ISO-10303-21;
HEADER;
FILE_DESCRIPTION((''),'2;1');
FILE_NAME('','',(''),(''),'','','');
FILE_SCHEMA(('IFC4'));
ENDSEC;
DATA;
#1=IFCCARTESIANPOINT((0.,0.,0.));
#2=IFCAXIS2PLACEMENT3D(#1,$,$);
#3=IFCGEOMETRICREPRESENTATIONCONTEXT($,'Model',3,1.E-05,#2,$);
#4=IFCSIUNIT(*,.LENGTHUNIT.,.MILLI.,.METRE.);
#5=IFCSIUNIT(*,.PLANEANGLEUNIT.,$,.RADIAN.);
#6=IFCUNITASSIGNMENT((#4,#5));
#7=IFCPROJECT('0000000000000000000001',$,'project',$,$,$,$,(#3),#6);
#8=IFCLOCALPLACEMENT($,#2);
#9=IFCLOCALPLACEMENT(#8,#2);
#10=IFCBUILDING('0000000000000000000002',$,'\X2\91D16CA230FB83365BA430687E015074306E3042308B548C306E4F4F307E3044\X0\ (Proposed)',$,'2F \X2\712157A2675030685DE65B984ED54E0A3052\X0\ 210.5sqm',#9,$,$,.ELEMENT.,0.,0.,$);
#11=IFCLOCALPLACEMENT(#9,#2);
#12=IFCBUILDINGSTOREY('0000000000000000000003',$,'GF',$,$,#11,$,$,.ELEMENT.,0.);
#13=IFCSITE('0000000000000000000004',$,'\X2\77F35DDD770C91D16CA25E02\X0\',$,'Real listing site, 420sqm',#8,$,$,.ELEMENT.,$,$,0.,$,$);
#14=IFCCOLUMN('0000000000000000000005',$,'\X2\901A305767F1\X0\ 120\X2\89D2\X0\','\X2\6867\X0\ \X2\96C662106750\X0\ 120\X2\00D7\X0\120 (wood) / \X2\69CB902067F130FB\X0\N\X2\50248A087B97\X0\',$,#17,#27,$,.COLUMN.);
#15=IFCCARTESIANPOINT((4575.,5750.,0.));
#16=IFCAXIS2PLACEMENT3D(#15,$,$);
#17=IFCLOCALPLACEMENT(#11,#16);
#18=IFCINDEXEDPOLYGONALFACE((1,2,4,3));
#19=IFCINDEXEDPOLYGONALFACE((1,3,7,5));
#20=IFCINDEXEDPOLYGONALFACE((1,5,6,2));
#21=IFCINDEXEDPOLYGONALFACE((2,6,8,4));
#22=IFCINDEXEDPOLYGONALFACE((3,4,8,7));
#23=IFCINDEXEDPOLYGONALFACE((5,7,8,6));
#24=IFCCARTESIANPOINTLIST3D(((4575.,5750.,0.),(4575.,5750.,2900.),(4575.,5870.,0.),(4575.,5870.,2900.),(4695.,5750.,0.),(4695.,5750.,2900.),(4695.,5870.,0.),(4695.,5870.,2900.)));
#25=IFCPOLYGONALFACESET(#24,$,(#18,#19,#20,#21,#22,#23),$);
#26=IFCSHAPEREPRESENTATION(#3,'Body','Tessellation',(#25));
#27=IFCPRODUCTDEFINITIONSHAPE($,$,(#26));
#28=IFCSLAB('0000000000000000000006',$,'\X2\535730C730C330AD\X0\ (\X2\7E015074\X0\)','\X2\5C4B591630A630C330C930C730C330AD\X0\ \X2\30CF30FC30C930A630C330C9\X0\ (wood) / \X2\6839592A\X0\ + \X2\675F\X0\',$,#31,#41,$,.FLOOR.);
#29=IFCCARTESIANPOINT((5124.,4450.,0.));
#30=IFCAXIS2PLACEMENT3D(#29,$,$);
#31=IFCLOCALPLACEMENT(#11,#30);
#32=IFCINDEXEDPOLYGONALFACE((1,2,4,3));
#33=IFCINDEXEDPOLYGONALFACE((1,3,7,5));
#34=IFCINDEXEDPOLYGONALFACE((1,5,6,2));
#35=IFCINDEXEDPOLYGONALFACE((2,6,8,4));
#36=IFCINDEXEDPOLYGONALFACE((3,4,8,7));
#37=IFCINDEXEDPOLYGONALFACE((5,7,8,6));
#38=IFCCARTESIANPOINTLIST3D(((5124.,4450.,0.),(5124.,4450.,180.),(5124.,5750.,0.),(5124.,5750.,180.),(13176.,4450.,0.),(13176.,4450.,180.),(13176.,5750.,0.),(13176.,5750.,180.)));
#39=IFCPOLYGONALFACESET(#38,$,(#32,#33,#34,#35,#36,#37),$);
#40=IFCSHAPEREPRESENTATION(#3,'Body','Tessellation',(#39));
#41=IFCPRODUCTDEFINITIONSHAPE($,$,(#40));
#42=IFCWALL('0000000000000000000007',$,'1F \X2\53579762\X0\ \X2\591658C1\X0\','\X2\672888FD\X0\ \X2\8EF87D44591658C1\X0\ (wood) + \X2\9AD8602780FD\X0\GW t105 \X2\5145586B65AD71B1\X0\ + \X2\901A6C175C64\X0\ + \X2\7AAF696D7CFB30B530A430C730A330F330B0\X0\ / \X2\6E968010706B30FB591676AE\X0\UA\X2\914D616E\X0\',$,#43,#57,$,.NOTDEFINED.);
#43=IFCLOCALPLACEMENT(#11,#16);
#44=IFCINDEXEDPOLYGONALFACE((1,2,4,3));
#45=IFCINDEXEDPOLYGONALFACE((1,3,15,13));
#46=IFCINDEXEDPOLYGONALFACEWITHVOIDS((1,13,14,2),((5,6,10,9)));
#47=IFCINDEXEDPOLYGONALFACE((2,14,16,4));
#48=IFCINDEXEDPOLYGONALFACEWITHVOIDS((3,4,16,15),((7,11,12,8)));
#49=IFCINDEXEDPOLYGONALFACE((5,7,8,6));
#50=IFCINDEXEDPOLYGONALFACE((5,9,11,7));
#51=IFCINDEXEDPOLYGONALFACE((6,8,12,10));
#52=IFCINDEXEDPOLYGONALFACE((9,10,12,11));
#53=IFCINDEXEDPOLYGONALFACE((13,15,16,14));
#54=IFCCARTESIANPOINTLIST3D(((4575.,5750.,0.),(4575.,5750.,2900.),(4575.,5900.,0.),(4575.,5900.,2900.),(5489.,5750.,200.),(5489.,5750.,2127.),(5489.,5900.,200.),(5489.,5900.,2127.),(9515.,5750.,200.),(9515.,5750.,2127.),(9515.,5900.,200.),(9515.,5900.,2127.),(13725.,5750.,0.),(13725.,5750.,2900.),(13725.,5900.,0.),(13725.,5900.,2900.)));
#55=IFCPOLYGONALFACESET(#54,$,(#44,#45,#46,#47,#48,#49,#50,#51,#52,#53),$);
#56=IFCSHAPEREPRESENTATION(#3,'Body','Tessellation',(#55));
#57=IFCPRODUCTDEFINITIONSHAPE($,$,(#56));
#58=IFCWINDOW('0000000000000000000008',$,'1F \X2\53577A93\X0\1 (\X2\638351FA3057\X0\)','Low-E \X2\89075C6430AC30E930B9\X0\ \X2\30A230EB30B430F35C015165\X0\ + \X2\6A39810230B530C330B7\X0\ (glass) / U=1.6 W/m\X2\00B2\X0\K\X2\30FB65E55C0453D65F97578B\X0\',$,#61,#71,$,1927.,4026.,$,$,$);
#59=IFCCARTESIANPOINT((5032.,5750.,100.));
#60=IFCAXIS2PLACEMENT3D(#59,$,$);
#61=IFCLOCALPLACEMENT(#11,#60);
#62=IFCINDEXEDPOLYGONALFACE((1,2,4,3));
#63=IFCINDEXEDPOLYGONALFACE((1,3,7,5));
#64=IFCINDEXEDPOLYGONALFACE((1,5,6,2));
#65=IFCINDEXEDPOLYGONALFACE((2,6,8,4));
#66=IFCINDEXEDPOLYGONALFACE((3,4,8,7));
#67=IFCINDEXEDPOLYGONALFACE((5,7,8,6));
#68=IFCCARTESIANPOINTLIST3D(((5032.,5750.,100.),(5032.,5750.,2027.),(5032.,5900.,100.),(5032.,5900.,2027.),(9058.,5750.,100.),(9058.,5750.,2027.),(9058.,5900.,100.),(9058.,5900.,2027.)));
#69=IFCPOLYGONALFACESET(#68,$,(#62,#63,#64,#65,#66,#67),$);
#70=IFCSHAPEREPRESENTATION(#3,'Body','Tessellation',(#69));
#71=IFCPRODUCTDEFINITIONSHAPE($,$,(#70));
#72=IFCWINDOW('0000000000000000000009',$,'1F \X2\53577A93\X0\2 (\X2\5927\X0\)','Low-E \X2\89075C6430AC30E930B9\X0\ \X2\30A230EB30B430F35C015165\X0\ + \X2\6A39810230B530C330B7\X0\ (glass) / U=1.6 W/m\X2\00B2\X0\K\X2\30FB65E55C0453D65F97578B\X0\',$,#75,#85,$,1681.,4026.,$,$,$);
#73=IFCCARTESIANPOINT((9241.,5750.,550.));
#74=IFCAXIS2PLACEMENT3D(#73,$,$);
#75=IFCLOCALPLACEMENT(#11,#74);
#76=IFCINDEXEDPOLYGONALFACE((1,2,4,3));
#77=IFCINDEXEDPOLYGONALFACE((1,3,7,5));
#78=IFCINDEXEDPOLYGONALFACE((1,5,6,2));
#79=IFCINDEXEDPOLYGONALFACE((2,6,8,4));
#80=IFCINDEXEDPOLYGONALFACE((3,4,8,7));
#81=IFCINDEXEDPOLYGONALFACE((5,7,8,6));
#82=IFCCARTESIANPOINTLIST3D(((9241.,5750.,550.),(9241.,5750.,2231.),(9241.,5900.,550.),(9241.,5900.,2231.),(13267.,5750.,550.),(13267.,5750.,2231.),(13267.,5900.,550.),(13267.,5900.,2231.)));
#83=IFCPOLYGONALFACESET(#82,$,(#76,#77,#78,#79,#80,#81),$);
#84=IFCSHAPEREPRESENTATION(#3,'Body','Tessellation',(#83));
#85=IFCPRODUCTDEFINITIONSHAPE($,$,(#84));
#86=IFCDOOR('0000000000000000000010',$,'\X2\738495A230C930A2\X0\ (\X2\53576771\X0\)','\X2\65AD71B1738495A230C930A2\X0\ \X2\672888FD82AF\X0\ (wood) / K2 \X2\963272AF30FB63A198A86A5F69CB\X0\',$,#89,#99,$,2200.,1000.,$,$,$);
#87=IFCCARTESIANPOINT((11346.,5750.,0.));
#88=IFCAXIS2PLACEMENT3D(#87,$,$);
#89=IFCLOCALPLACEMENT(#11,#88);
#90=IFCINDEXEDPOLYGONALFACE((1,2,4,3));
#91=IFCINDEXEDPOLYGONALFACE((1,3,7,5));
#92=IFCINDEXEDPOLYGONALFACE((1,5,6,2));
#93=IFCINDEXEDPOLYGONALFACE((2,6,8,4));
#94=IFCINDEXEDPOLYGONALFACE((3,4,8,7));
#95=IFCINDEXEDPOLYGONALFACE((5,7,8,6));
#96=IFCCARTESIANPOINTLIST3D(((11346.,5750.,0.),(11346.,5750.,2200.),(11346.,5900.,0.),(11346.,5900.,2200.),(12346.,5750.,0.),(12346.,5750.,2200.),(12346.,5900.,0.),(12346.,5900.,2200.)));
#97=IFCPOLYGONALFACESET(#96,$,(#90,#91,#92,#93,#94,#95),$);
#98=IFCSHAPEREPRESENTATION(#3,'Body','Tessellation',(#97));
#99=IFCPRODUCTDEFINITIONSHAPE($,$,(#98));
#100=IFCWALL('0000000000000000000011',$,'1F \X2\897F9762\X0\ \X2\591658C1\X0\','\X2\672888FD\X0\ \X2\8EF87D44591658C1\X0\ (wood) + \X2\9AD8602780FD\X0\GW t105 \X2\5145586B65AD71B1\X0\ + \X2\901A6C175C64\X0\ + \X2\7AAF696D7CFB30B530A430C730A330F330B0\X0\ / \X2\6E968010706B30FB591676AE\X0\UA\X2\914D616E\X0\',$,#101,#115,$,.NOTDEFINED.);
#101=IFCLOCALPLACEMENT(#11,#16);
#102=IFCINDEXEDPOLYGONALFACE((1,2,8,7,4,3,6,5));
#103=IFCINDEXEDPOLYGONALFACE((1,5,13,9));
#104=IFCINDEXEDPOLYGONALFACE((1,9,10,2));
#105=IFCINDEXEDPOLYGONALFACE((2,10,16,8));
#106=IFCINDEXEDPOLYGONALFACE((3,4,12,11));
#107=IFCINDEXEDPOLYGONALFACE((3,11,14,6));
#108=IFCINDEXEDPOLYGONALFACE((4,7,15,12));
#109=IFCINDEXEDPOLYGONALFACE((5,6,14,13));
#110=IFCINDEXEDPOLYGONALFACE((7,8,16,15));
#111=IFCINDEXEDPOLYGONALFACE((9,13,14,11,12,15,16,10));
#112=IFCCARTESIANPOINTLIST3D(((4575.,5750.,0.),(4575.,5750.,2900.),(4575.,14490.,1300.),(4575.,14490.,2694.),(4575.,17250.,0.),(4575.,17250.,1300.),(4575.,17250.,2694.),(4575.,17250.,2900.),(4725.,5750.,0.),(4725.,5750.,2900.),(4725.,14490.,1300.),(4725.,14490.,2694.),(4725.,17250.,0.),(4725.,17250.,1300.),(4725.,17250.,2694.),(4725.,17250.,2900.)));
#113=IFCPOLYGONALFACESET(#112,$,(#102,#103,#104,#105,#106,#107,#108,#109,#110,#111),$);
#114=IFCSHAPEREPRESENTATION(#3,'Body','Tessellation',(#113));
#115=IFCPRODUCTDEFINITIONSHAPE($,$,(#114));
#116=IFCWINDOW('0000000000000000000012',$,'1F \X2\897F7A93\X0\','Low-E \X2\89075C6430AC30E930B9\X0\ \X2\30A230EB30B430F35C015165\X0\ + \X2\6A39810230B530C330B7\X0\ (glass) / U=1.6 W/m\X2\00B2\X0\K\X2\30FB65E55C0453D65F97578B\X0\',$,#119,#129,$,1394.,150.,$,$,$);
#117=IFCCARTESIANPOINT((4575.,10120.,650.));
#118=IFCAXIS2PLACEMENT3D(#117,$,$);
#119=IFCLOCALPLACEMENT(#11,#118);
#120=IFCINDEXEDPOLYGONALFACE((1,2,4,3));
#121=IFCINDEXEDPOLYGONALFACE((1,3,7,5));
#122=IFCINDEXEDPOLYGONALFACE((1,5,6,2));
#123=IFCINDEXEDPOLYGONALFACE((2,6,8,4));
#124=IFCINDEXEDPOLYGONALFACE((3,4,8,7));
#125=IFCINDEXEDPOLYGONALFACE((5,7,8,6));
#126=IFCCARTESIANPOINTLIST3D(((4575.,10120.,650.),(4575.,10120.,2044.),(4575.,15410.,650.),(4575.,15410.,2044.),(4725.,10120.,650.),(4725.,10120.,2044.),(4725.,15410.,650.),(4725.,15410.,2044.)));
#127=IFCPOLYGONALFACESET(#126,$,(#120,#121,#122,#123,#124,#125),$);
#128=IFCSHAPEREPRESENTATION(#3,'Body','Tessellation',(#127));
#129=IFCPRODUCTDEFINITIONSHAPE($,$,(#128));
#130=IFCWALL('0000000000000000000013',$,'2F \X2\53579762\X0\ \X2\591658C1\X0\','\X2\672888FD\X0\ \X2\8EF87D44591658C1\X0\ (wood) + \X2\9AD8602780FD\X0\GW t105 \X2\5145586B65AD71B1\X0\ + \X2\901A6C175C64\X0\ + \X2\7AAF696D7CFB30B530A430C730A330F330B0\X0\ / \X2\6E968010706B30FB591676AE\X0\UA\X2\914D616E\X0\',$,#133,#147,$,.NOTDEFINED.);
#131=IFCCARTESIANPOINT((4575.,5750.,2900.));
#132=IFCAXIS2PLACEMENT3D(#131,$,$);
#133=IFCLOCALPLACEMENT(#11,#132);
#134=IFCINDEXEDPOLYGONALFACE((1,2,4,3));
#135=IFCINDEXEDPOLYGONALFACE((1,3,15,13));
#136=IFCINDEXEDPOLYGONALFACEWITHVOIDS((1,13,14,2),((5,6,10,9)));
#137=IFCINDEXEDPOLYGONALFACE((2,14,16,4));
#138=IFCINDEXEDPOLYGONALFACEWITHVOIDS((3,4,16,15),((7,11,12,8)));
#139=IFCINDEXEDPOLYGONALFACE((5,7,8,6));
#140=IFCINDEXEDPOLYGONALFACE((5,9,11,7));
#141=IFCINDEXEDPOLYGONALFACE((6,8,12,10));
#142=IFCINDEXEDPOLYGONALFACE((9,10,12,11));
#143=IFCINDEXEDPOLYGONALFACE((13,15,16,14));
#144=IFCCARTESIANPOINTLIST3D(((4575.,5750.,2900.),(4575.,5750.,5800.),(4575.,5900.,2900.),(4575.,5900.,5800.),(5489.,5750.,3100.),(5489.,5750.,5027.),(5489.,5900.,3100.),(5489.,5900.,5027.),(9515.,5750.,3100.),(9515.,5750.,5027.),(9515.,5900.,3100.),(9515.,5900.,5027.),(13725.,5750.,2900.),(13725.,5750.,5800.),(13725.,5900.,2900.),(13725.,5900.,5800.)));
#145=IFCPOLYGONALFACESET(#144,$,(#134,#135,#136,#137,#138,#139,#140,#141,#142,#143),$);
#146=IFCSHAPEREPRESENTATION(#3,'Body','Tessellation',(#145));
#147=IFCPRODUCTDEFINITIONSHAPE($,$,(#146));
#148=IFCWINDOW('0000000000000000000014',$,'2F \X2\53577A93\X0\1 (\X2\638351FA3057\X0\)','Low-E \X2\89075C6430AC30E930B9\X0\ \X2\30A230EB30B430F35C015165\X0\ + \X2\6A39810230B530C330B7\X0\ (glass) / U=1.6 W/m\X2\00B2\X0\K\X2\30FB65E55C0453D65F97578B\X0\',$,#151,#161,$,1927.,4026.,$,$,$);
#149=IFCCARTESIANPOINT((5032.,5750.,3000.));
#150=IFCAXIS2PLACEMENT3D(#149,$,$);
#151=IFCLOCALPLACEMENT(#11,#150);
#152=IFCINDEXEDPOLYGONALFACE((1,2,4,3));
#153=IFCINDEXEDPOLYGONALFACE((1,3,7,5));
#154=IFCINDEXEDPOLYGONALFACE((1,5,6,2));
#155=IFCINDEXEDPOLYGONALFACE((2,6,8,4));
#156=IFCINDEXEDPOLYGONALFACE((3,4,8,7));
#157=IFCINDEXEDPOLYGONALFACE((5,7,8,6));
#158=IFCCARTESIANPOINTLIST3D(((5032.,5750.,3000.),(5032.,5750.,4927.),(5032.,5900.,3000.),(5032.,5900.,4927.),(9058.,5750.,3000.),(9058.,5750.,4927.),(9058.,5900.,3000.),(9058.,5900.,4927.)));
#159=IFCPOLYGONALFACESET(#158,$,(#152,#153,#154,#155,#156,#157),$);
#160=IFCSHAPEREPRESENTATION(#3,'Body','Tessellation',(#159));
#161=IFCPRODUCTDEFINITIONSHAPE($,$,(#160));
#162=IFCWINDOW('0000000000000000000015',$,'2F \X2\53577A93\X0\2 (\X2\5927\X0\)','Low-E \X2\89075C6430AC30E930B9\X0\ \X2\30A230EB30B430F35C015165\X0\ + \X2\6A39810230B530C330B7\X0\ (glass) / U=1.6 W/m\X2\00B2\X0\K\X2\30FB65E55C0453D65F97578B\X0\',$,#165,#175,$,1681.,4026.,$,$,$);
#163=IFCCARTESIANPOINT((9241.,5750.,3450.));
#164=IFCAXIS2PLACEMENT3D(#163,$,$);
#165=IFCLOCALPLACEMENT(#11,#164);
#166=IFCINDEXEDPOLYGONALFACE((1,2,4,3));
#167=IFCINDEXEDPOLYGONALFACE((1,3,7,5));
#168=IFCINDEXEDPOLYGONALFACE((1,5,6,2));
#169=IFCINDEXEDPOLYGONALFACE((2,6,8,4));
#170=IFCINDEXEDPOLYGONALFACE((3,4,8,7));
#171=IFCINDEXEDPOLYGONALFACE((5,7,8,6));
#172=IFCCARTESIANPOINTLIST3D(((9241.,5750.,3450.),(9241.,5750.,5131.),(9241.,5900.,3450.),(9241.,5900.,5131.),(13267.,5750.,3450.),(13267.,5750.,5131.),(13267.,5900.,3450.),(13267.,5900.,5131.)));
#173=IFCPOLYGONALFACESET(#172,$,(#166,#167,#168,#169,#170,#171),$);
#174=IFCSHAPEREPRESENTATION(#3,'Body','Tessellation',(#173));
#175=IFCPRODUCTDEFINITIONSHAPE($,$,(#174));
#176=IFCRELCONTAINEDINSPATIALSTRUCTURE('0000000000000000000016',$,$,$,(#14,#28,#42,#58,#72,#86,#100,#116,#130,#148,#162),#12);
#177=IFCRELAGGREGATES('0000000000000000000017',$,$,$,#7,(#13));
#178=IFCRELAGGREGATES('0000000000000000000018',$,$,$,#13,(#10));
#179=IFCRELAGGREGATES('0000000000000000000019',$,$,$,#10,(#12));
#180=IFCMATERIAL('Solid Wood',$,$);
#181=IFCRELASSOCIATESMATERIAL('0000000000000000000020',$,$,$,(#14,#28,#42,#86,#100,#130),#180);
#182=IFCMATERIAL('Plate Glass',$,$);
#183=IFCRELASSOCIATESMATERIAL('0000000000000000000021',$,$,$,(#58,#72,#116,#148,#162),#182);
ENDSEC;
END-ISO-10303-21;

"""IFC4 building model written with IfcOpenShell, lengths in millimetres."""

from ifc_helpers import new_model, si_unit, frame, frame_2d, origin, place, context, project, spatial, rectangle, extrude, material, element, fill, save


model = new_model("IFC4")

# Units and contexts
model_context = context("Model", 3, precision=1e-05, world=origin())
ifc_project = project(units=[si_unit("LENGTHUNIT", "METRE", prefix="MILLI"), si_unit("PLANEANGLEUNIT", "RADIAN")], contexts=[model_context])

# Site, building, storey
site_placement = place(None, origin())
site = spatial("IfcSite", under=ifc_project, at=site_placement, Name="石川県金沢市", ObjectType="Real listing site, 420sqm", CompositionType="ELEMENT", RefElevation=0.0)
building_placement = place(site_placement, origin())
building = spatial("IfcBuilding", under=site, at=building_placement, Name="金沢・茶室と縁側のある和の住まい (Proposed)", ObjectType="2F 無垢材と左官仕上げ 210.5sqm", CompositionType="ELEMENT", ElevationOfRefHeight=0.0, ElevationOfTerrain=0.0)
storey_placement = place(building_placement, origin())
storey = spatial("IfcBuildingStorey", under=building, at=storey_placement, Name="GF", CompositionType="ELEMENT", Elevation=0.0)

# Column
ifc_material_1 = material(Name="Solid Wood")
column_placement = place(storey_placement, frame((4575.0, 5750.0, 0.0)))
element("IfcColumn", 1, at=column_placement, inside=storey, material=ifc_material_1, Name="通し柱 120角", Description="桧 集成材 120×120 (wood) / 構造柱・N値計算", PredefinedType="COLUMN", context=model_context, shape_type="SweptSolid", body=[
    extrude(rectangle(XDim=120.0, YDim=120.0, at=frame_2d((60.0, 60.0))), frame((4575.0, 5750.0, 0.0)), (0.0, 0.0, 1.0), 2900.0),
])

# Slab
slab_1_placement = place(storey_placement, frame((5124.0, 4450.0, 0.0)))
element("IfcSlab", 2, at=slab_1_placement, inside=storey, material=ifc_material_1, Name="南デッキ (縁側)", Description="屋外ウッドデッキ ハードウッド (wood) / 根太 + 束", PredefinedType="FLOOR", context=model_context, shape_type="SweptSolid", body=[
    extrude(rectangle(XDim=8052.0, YDim=1300.0, at=frame_2d((4026.0, 650.0))), frame((5124.0, 4450.0, 0.0)), (0.0, 0.0, 1.0), 180.0),
])

# Wall, openings, windows, door
wall_1_placement = place(storey_placement, frame((4575.0, 5750.0, 0.0)))
wall_1 = element("IfcWall", 3, at=wall_1_placement, inside=storey, material=ifc_material_1, Name="1F 南面 外壁", Description="木製 軸組外壁 (wood) + 高性能GW t105 充填断熱 + 通気層 + 窯業系サイディング / 準耐火・外皮UA配慮", PredefinedType="NOTDEFINED", context=model_context, shape_type="SweptSolid", body=[
    extrude(rectangle(XDim=9150.0, YDim=150.0, at=frame_2d((4575.0, 75.0))), frame((4575.0, 5750.0, 0.0)), (0.0, 0.0, 1.0), 2900.0),
])
opening_1_placement = place(storey_placement, frame((5032.0, 5750.0, 100.0)))
opening_1 = element("IfcOpeningElement", 4, at=opening_1_placement, cuts=wall_1, PredefinedType="NOTDEFINED", context=model_context, shape_type="SweptSolid", body=[
    extrude(rectangle(XDim=4026.0, YDim=150.0, at=frame_2d((2013.0, 75.0))), frame((5032.0, 5750.0, 100.0)), (0.0, 0.0, 1.0), 1927.0),
])
opening_2_placement = place(storey_placement, frame((9241.0, 5750.0, 550.0)))
opening_2 = element("IfcOpeningElement", 5, at=opening_2_placement, cuts=wall_1, PredefinedType="NOTDEFINED", context=model_context, shape_type="SweptSolid", body=[
    extrude(rectangle(XDim=4026.0, YDim=150.0, at=frame_2d((2013.0, 75.0))), frame((9241.0, 5750.0, 550.0)), (0.0, 0.0, 1.0), 1681.0),
])
opening_3_placement = place(storey_placement, frame((11346.0, 5750.0, 0.0)))
opening_3 = element("IfcOpeningElement", 6, at=opening_3_placement, cuts=wall_1, PredefinedType="NOTDEFINED", context=model_context, shape_type="SweptSolid", body=[
    extrude(rectangle(XDim=1000.0, YDim=150.0, at=frame_2d((500.0, 75.0))), frame((11346.0, 5750.0, 0.0)), (0.0, 0.0, 1.0), 2200.0),
])
ifc_material_2 = material(Name="Plate Glass")
window_1_placement = place(storey_placement, frame((5032.0, 5750.0, 100.0)))
window_1 = element("IfcWindow", 7, at=window_1_placement, inside=storey, material=ifc_material_2, Name="1F 南窓1 (掃出し)", Description="Low-E 複層ガラス アルゴン封入 + 樹脂サッシ (glass) / U=1.6 W/m²K・日射取得型", OverallHeight=1927.0, OverallWidth=4026.0, context=model_context, shape_type="SweptSolid", body=[
    extrude(rectangle(XDim=4026.0, YDim=150.0, at=frame_2d((2013.0, 75.0))), frame((5032.0, 5750.0, 100.0)), (0.0, 0.0, 1.0), 1927.0),
])
fill(opening_1, window_1)
window_2_placement = place(storey_placement, frame((9241.0, 5750.0, 550.0)))
window_2 = element("IfcWindow", 8, at=window_2_placement, inside=storey, material=ifc_material_2, Name="1F 南窓2 (大)", Description="Low-E 複層ガラス アルゴン封入 + 樹脂サッシ (glass) / U=1.6 W/m²K・日射取得型", OverallHeight=1681.0, OverallWidth=4026.0, context=model_context, shape_type="SweptSolid", body=[
    extrude(rectangle(XDim=4026.0, YDim=150.0, at=frame_2d((2013.0, 75.0))), frame((9241.0, 5750.0, 550.0)), (0.0, 0.0, 1.0), 1681.0),
])
fill(opening_2, window_2)
door_placement = place(storey_placement, frame((11346.0, 5750.0, 0.0)))
door = element("IfcDoor", 9, at=door_placement, inside=storey, material=ifc_material_1, Name="玄関ドア (南東)", Description="断熱玄関ドア 木製芯 (wood) / K2 防犯・採風機構", OverallHeight=2200.0, OverallWidth=1000.0, context=model_context, shape_type="SweptSolid", body=[
    extrude(rectangle(XDim=1000.0, YDim=150.0, at=frame_2d((500.0, 75.0))), frame((11346.0, 5750.0, 0.0)), (0.0, 0.0, 1.0), 2200.0),
])
fill(opening_3, door)

# Wall, opening, window
wall_2_placement = place(storey_placement, frame((4575.0, 5750.0, 0.0)))
wall_2 = element("IfcWall", 10, at=wall_2_placement, inside=storey, material=ifc_material_1, Name="1F 西面 外壁", Description="木製 軸組外壁 (wood) + 高性能GW t105 充填断熱 + 通気層 + 窯業系サイディング / 準耐火・外皮UA配慮", PredefinedType="NOTDEFINED", context=model_context, shape_type="SweptSolid", body=[
    extrude(rectangle(XDim=150.0, YDim=11500.0, at=frame_2d((75.0, 5750.0))), frame((4575.0, 5750.0, 0.0)), (0.0, 0.0, 1.0), 2900.0),
])
opening_4_placement = place(storey_placement, frame((4575.0, 10120.0, 650.0)))
opening_4 = element("IfcOpeningElement", 11, at=opening_4_placement, cuts=wall_2, PredefinedType="NOTDEFINED", context=model_context, shape_type="SweptSolid", body=[
    extrude(rectangle(XDim=150.0, YDim=5290.0, at=frame_2d((75.0, 2645.0))), frame((4575.0, 10120.0, 650.0)), (0.0, 0.0, 1.0), 1394.0),
])
window_3_placement = place(storey_placement, frame((4575.0, 10120.0, 650.0)))
window_3 = element("IfcWindow", 12, at=window_3_placement, inside=storey, material=ifc_material_2, Name="1F 西窓", Description="Low-E 複層ガラス アルゴン封入 + 樹脂サッシ (glass) / U=1.6 W/m²K・日射取得型", OverallHeight=1394.0, OverallWidth=150.0, context=model_context, shape_type="SweptSolid", body=[
    extrude(rectangle(XDim=150.0, YDim=5290.0, at=frame_2d((75.0, 2645.0))), frame((4575.0, 10120.0, 650.0)), (0.0, 0.0, 1.0), 1394.0),
])
fill(opening_4, window_3)

# Wall, openings, windows
wall_3_placement = place(storey_placement, frame((4575.0, 5750.0, 2900.0)))
wall_3 = element("IfcWall", 13, at=wall_3_placement, inside=storey, material=ifc_material_1, Name="2F 南面 外壁", Description="木製 軸組外壁 (wood) + 高性能GW t105 充填断熱 + 通気層 + 窯業系サイディング / 準耐火・外皮UA配慮", PredefinedType="NOTDEFINED", context=model_context, shape_type="SweptSolid", body=[
    extrude(rectangle(XDim=9150.0, YDim=150.0, at=frame_2d((4575.0, 75.0))), frame((4575.0, 5750.0, 2900.0)), (0.0, 0.0, 1.0), 2900.0),
])
opening_5_placement = place(storey_placement, frame((5032.0, 5750.0, 3000.0)))
opening_5 = element("IfcOpeningElement", 14, at=opening_5_placement, cuts=wall_3, PredefinedType="NOTDEFINED", context=model_context, shape_type="SweptSolid", body=[
    extrude(rectangle(XDim=4026.0, YDim=150.0, at=frame_2d((2013.0, 75.0))), frame((5032.0, 5750.0, 3000.0)), (0.0, 0.0, 1.0), 1927.0),
])
opening_6_placement = place(storey_placement, frame((9241.0, 5750.0, 3450.0)))
opening_6 = element("IfcOpeningElement", 15, at=opening_6_placement, cuts=wall_3, PredefinedType="NOTDEFINED", context=model_context, shape_type="SweptSolid", body=[
    extrude(rectangle(XDim=4026.0, YDim=150.0, at=frame_2d((2013.0, 75.0))), frame((9241.0, 5750.0, 3450.0)), (0.0, 0.0, 1.0), 1681.0),
])
window_4_placement = place(storey_placement, frame((5032.0, 5750.0, 3000.0)))
window_4 = element("IfcWindow", 16, at=window_4_placement, inside=storey, material=ifc_material_2, Name="2F 南窓1 (掃出し)", Description="Low-E 複層ガラス アルゴン封入 + 樹脂サッシ (glass) / U=1.6 W/m²K・日射取得型", OverallHeight=1927.0, OverallWidth=4026.0, context=model_context, shape_type="SweptSolid", body=[
    extrude(rectangle(XDim=4026.0, YDim=150.0, at=frame_2d((2013.0, 75.0))), frame((5032.0, 5750.0, 3000.0)), (0.0, 0.0, 1.0), 1927.0),
])
fill(opening_5, window_4)
window_5_placement = place(storey_placement, frame((9241.0, 5750.0, 3450.0)))
window_5 = element("IfcWindow", 17, at=window_5_placement, inside=storey, material=ifc_material_2, Name="2F 南窓2 (大)", Description="Low-E 複層ガラス アルゴン封入 + 樹脂サッシ (glass) / U=1.6 W/m²K・日射取得型", OverallHeight=1681.0, OverallWidth=4026.0, context=model_context, shape_type="SweptSolid", body=[
    extrude(rectangle(XDim=4026.0, YDim=150.0, at=frame_2d((2013.0, 75.0))), frame((9241.0, 5750.0, 3450.0)), (0.0, 0.0, 1.0), 1681.0),
])
fill(opening_6, window_5)

save(model, "model.ifc")
